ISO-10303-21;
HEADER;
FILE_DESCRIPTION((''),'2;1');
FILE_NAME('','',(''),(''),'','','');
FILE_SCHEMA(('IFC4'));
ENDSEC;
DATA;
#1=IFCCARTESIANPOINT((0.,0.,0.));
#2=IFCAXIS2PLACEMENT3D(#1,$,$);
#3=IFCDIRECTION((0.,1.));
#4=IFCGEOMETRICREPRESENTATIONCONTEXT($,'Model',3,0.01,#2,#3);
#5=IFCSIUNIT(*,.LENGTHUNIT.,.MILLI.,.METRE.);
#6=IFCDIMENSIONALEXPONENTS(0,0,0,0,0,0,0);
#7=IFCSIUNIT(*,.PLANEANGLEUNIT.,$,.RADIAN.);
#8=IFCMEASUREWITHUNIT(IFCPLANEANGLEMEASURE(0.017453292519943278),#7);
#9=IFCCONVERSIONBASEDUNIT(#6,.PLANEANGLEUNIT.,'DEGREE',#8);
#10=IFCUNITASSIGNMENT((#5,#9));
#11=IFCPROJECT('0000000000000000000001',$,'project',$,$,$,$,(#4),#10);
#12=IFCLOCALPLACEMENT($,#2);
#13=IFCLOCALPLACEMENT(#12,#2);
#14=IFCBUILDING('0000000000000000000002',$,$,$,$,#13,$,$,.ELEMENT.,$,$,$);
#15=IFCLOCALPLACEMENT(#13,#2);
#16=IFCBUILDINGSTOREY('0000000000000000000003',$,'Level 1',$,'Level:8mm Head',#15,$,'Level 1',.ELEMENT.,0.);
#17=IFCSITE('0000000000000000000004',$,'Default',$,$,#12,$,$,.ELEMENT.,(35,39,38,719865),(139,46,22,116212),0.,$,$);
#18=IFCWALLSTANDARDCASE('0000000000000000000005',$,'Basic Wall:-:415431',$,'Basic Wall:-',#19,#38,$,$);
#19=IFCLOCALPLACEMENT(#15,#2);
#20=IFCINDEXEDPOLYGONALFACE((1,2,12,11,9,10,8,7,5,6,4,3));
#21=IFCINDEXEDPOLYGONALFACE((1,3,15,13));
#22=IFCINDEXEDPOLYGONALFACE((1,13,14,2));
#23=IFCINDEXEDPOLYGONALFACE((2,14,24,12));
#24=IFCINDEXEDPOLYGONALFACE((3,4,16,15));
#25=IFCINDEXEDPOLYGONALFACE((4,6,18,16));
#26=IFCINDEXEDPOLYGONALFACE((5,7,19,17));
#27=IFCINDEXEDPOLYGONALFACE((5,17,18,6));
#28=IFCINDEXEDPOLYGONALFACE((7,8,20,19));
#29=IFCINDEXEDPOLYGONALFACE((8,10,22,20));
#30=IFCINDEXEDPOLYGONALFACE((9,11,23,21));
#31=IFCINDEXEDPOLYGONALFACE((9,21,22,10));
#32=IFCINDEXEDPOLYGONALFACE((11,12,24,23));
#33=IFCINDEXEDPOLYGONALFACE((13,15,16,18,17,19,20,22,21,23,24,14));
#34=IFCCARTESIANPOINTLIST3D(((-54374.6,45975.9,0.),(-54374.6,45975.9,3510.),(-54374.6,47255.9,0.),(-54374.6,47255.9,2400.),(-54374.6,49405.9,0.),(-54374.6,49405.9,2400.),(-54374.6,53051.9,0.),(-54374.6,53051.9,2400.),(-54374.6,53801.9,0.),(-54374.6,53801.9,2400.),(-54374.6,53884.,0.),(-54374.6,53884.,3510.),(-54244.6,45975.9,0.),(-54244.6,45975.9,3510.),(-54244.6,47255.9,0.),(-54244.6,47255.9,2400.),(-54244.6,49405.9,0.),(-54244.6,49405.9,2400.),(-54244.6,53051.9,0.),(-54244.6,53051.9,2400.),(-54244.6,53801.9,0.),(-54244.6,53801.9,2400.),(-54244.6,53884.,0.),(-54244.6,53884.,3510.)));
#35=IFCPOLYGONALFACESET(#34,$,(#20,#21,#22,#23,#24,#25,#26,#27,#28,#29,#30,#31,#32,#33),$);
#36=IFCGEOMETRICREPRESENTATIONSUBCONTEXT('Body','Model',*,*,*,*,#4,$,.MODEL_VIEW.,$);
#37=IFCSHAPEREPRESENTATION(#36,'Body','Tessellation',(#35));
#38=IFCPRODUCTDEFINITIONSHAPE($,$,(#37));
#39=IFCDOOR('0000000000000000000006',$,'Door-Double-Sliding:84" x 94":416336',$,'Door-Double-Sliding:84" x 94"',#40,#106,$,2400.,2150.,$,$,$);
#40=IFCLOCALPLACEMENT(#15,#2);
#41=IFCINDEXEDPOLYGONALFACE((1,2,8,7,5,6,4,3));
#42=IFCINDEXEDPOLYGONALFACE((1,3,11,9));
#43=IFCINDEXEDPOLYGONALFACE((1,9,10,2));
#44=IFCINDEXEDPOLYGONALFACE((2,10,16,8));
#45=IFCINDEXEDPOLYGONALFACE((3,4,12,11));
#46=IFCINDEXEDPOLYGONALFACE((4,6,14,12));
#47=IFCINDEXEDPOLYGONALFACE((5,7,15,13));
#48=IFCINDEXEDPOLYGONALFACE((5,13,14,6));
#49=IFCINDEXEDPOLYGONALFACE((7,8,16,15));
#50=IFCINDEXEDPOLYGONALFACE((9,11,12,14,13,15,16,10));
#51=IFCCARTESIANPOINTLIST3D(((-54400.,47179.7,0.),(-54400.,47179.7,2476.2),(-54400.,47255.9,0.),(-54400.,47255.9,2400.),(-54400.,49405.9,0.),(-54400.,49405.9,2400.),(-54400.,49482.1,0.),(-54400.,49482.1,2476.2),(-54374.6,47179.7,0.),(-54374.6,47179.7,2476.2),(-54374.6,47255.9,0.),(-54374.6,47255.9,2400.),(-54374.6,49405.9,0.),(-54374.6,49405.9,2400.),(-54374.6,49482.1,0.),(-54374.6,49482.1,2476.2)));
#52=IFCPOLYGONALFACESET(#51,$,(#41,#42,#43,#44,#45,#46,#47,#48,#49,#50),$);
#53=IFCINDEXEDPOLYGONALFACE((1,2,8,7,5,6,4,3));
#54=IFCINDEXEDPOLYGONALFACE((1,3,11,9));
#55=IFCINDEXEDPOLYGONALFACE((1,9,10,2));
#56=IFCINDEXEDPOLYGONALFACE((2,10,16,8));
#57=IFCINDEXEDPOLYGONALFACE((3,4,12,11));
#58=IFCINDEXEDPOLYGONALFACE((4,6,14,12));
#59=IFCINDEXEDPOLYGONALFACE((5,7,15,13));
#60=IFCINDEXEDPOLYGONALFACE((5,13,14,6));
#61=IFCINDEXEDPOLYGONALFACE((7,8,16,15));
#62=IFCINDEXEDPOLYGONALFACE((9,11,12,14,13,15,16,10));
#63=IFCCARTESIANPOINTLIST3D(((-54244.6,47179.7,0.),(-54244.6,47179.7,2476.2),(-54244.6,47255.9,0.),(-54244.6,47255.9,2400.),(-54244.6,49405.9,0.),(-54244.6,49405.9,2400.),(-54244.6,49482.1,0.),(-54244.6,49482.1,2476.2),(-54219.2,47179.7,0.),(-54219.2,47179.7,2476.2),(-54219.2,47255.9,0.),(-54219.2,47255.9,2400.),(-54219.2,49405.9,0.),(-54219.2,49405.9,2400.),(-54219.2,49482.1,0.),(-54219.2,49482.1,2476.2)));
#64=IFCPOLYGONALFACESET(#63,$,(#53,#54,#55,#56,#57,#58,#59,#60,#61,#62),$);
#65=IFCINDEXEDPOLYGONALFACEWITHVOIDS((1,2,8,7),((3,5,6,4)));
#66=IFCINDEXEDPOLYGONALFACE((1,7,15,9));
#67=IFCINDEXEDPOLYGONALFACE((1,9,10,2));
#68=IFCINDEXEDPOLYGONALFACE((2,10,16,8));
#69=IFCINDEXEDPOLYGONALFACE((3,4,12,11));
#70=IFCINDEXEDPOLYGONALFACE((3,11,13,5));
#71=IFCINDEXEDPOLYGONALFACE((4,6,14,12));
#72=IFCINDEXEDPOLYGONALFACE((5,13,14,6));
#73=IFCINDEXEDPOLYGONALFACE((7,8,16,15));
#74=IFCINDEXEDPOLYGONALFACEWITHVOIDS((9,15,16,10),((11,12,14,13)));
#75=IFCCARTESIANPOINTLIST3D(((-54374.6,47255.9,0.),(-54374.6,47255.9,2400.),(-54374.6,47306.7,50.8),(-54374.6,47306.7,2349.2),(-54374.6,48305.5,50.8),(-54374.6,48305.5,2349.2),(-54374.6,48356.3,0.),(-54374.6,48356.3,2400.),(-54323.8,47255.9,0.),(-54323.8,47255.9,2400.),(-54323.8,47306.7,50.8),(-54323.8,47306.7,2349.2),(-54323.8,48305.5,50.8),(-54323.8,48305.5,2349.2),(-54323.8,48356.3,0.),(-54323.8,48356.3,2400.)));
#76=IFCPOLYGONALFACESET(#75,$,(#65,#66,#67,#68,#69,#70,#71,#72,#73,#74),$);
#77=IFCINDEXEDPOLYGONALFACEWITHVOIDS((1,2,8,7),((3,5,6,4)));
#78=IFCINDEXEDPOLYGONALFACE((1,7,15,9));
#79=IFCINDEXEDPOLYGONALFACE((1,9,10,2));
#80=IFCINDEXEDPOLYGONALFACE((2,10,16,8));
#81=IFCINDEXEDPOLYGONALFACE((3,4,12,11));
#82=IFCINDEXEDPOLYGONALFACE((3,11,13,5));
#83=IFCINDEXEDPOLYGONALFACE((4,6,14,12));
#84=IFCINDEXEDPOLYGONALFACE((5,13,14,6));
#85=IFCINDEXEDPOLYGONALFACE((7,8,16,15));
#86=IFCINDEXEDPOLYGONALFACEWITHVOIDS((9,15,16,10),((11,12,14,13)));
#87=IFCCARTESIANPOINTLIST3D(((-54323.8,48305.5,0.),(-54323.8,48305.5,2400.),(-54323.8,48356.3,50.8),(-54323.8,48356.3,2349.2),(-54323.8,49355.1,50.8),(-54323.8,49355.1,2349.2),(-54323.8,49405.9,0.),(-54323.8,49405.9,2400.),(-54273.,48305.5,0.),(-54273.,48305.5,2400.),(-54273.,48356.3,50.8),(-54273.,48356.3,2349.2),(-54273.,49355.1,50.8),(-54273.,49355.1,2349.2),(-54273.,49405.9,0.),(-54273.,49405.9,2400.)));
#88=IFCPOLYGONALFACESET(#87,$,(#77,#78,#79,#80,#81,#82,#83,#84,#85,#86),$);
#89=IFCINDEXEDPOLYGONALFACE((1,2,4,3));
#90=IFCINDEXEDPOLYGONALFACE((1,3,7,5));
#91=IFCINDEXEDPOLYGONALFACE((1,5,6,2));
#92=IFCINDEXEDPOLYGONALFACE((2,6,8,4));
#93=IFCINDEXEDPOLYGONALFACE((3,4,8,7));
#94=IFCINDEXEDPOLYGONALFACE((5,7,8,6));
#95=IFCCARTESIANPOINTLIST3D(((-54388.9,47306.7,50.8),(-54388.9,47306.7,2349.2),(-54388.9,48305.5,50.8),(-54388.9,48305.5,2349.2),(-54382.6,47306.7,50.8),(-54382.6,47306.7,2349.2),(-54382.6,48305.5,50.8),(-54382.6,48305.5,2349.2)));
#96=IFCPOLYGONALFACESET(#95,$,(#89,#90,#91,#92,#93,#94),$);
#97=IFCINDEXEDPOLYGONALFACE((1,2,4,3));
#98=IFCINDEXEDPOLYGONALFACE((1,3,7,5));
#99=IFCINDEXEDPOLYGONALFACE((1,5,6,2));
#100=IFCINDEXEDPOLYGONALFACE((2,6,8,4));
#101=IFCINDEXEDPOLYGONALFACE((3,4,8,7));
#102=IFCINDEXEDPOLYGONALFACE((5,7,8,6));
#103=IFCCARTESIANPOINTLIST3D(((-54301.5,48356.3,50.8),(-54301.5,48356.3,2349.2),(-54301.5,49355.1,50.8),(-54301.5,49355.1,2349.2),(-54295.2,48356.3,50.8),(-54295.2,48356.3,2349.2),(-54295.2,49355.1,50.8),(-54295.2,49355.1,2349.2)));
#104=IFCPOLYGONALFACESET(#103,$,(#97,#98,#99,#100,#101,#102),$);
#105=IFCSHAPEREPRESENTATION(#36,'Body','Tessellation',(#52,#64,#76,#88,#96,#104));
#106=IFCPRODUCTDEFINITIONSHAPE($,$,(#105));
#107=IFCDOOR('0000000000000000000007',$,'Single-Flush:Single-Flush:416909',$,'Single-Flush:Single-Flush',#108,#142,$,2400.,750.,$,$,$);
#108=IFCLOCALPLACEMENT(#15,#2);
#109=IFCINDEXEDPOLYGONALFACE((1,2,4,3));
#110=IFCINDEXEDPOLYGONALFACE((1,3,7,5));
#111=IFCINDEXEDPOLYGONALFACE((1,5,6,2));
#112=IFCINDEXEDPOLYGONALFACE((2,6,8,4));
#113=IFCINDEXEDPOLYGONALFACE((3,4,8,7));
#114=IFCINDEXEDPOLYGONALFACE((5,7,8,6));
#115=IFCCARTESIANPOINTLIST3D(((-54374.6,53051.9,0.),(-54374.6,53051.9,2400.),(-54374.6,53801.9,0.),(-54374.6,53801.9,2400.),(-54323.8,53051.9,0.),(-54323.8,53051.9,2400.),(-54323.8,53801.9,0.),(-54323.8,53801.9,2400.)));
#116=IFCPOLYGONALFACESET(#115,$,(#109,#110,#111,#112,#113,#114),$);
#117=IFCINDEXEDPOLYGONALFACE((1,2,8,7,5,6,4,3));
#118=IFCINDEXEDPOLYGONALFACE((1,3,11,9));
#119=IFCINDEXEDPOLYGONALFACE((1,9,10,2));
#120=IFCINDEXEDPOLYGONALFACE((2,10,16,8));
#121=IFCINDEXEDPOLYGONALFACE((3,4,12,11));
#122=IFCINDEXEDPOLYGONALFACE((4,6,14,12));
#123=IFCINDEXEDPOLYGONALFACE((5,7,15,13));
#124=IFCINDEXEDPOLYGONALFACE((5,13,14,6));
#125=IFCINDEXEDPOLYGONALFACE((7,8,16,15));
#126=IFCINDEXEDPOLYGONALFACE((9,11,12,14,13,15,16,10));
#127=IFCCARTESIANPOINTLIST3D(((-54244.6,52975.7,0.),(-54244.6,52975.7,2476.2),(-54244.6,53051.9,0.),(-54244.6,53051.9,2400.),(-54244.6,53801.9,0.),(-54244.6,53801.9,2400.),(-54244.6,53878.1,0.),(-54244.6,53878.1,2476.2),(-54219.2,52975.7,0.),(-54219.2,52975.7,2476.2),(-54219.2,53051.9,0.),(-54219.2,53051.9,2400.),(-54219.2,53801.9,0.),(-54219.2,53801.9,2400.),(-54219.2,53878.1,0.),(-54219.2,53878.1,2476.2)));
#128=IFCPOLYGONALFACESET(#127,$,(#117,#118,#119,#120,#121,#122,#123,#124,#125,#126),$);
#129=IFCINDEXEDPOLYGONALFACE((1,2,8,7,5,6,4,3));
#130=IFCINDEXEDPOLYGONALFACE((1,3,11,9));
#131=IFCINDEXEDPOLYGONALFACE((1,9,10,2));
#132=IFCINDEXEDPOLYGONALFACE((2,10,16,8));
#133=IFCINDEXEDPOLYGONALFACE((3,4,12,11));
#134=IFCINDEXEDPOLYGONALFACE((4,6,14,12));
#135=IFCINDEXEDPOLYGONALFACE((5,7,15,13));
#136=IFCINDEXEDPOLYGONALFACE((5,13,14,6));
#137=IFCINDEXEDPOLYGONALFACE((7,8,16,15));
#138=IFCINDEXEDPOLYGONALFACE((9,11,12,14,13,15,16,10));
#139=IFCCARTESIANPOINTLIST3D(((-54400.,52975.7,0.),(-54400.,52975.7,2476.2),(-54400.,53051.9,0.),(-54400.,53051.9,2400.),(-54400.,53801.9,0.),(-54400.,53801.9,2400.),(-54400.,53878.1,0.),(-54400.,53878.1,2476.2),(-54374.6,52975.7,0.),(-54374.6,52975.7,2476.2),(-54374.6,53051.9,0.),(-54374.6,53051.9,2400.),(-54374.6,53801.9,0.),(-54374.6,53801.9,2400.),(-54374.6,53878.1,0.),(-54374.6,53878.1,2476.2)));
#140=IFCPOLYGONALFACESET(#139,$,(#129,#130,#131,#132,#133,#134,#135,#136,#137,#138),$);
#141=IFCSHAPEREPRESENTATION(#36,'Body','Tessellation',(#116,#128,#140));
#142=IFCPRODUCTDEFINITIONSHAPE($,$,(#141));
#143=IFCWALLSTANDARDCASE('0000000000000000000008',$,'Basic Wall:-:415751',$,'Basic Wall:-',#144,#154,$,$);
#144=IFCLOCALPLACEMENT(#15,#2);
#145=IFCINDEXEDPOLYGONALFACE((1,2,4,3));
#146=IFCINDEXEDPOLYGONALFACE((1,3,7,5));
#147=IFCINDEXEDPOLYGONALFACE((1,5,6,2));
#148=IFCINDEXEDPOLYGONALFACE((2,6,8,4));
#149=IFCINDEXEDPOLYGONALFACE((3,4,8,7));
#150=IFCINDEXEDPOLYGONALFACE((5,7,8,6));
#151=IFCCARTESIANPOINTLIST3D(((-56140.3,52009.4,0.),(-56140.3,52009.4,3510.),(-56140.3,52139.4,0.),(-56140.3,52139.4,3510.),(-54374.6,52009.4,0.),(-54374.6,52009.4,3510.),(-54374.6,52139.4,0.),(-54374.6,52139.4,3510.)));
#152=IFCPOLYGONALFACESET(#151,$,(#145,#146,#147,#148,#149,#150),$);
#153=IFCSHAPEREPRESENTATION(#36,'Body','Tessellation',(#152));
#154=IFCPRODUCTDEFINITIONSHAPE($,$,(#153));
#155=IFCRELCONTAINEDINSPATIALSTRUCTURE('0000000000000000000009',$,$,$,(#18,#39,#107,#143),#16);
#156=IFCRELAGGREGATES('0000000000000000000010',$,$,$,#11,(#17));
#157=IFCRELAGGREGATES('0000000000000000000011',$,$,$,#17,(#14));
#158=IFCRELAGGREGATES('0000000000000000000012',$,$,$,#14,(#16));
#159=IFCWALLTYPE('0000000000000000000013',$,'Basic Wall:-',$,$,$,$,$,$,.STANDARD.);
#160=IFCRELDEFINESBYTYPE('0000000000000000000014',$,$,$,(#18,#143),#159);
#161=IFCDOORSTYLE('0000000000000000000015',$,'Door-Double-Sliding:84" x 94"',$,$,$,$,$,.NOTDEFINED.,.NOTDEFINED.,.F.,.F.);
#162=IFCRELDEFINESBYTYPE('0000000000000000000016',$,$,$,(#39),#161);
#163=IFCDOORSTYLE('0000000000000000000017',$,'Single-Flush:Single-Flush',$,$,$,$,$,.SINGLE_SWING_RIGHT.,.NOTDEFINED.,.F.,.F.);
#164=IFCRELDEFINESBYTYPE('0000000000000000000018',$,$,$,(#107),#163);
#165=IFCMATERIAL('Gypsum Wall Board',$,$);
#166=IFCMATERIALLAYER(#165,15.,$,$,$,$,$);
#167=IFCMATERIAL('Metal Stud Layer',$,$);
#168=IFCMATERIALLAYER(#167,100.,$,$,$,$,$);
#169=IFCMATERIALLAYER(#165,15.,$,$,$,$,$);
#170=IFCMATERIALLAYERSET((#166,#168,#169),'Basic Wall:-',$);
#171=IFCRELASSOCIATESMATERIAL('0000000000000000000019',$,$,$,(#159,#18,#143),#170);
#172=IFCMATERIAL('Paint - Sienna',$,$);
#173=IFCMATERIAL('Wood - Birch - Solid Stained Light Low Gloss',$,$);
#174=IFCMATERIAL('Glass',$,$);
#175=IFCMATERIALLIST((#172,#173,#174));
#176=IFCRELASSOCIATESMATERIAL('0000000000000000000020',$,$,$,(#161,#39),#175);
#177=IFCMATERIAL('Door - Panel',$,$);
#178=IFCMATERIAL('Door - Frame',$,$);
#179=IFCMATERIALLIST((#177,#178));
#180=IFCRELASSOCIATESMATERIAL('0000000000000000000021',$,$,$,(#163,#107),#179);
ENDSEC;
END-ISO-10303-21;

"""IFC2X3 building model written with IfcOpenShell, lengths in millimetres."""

from ifc_helpers import new_model, entity, si_unit, converted_unit, direction, frame, frame_2d, origin, origin_2d_with_axis, place, context, subcontext, project, spatial, polyline, rectangle, outline, extrude, source, transform, mapped, material, material_list, layer, layer_set, layer_usage, type_object, type_shapes, element, fill, save


model = new_model("IFC2X3")

# Units and contexts
model_context = context("Model", 3, precision=0.01, world=origin(), true_north=direction((0.0, 1.0)))
body_context = subcontext(model_context, "Body", "Model", "MODEL_VIEW")
ifc_project = project(units=[si_unit("LENGTHUNIT", "METRE", prefix="MILLI"), converted_unit("PLANEANGLEUNIT", "DEGREE", entity("IfcPlaneAngleMeasure", 0.017453292519943278), si_unit("PLANEANGLEUNIT", "RADIAN"), dimensions=[0, 0, 0, 0, 0, 0, 0])], contexts=[model_context])

# Site, building, storey
site_placement = place(None, origin())
site = spatial("IfcSite", under=ifc_project, at=site_placement, Name="Default", CompositionType="ELEMENT", RefLatitude=(35, 39, 38, 719865), RefLongitude=(139, 46, 22, 116212), RefElevation=0.0)
building_placement = place(site_placement, origin())
building = spatial("IfcBuilding", under=site, at=building_placement, CompositionType="ELEMENT")
storey_placement = place(building_placement, origin())
storey = spatial("IfcBuildingStorey", under=building, at=storey_placement, Name="Level 1", ObjectType="Level:8mm Head", LongName="Level 1", CompositionType="ELEMENT", Elevation=0.0)

# Shared definitions
ifc_material_1 = material(Name="Glass")

# Wall, openings, doors
ifc_material_2 = material(Name="Gypsum Wall Board")
ifc_layer_1 = layer(ifc_material_2, 15.0)
ifc_material_3 = material(Name="Metal Stud Layer")
ifc_layer_2 = layer(ifc_material_3, 100.0)
ifc_layer_3 = layer(ifc_material_2, 15.0)
ifc_layer_set = layer_set([ifc_layer_1, ifc_layer_2, ifc_layer_3], Name="Basic Wall:-")
ifc_layer_usage_1 = layer_usage(ifc_layer_set, "AXIS2", "NEGATIVE", 65.0)
wall_type = type_object("IfcWallType", Name="Basic Wall:-", PredefinedType="STANDARD", material=ifc_layer_set)
wall_1_placement = place(storey_placement, frame((-54309.6, 45975.9, 0.0), z_axis=(0.0, 0.0, 1.0), x_axis=(0.0, 1.0, 0.0)))
wall_1 = element("IfcWallStandardCase", 1, at=wall_1_placement, inside=storey, type_object=wall_type, material=ifc_layer_usage_1, Name="Basic Wall:-:415431", ObjectType="Basic Wall:-", context=body_context, shape_type="SweptSolid", body=[
    extrude(rectangle(XDim=7908.1, YDim=130.0, at=frame_2d((3954.1, 0.0), x_axis=(-1.0, 0.0))), origin(), (0.0, 0.0, 1.0), 3510.0),
])
opening_1_placement = place(wall_1_placement, frame((1280.0, -65.0, 0.0)))
opening_1 = element("IfcOpeningElement", 2, at=opening_1_placement, cuts=wall_1, ObjectType="Opening", context=body_context, shape_type="SweptSolid", body=[
    extrude(rectangle(XDim=2400.0, YDim=2150.0, at=frame_2d((1200.0, 1075.0), x_axis=(-1.0, 0.0))), frame((0.0, 0.0, 0.0), z_axis=(0.0, 1.0, 0.0), x_axis=(0.0, 0.0, 1.0)), (0.0, 0.0, 1.0), 130.0),
])
opening_2_placement = place(wall_1_placement, frame((7075.9, -65.0, 0.0)))
opening_2 = element("IfcOpeningElement", 3, at=opening_2_placement, cuts=wall_1, ObjectType="Opening", context=body_context, shape_type="SweptSolid", body=[
    extrude(rectangle(XDim=750.0, YDim=2400.0, at=frame_2d((1200.0, 375.0), x_axis=(0.0, 1.0))), frame((0.0, 0.0, 0.0), z_axis=(0.0, 1.0, 0.0), x_axis=(0.0, 0.0, 1.0)), (0.0, 0.0, 1.0), 130.0),
])
ifc_material_4 = material(Name="Paint - Sienna")
ifc_material_5 = material(Name="Wood - Birch - Solid Stained Light Low Gloss")
ifc_material_list_1 = material_list([ifc_material_4, ifc_material_5, ifc_material_1])
door_style_1 = type_object("IfcDoorStyle", Name="Door-Double-Sliding:84\" x 94\"", ConstructionType="NOTDEFINED", OperationType="NOTDEFINED", ParameterTakesPrecedence=False, Sizeable=False, material=ifc_material_list_1)
shared_shape_1 = source(origin(), body_context, "Body", "SweptSolid", [
    extrude(outline(polyline([(-1151.2, -1219.0), (-1075.0, -1219.0), (-1075.0, 1181.0), (1075.0, 1180.9), (1075.0, -1219.1), (1151.2, -1219.1), (1151.2, 1257.1), (-1151.2, 1257.2), (-1151.2, -1219.0)])), frame((1075.0, 130.0, 1219.0), z_axis=(0.0, 1.0, 0.0), x_axis=(-1.0, 0.0, 0.0)), (0.0, 0.0, 1.0), 25.4),
    extrude(outline(polyline([(-1219.0, -1151.2), (1257.1, -1151.2), (1257.1, 1151.2), (-1219.0, 1151.2), (-1219.0, 1075.0), (1180.9, 1075.0), (1180.9, -1075.0), (-1219.0, -1075.0), (-1219.0, -1151.2)])), frame((1075.0, -25.4, 1219.0), z_axis=(0.0, 1.0, 0.0), x_axis=(0.0, 0.0, 1.0)), (0.0, 0.0, 1.0), 25.4),
    extrude(outline(polyline([(-1200.0, -550.2), (1200.0, -550.2), (1200.0, 550.2), (-1200.0, 550.2), (-1200.0, -550.2)]), holes=[polyline([(-1149.2, -499.4), (-1149.2, 499.4), (1149.2, 499.4), (1149.2, -499.4), (-1149.2, -499.4)])]), frame((550.2, 79.2, 1200.0), z_axis=(0.0, 1.0, 0.0), x_axis=(0.0, 0.0, -1.0)), (0.0, 0.0, 1.0), 50.8),
    extrude(outline(polyline([(-550.2, -1200.0), (550.2, -1200.0), (550.2, 1200.0), (-550.2, 1200.0), (-550.2, -1200.0)]), holes=[polyline([(-499.4, -1149.2), (-499.4, 1149.2), (499.4, 1149.2), (499.4, -1149.2), (-499.4, -1149.2)])]), frame((1599.8, 28.4, 1200.0), z_axis=(0.0, 1.0, 0.0), x_axis=(1.0, 0.0, 0.0)), (0.0, 0.0, 1.0), 50.8),
    extrude(rectangle(XDim=6.4, YDim=998.8, at=origin_2d_with_axis()), frame((550.2, 141.2, 50.8), z_axis=(0.0, 0.0, 1.0), x_axis=(0.0, 1.0, 0.0)), (0.0, 0.0, 1.0), 2298.4),
    extrude(rectangle(XDim=6.3, YDim=998.8, at=frame_2d((0.0, 0.0), x_axis=(1.0, 0.0))), frame((1599.8, 53.8, 50.8), z_axis=(0.0, 0.0, 1.0), x_axis=(0.0, -1.0, 0.0)), (0.0, 0.0, 1.0), 2298.4),
])
type_shapes(door_style_1, [shared_shape_1])
door_1_placement = place(opening_1_placement, origin())
door_1 = element("IfcDoor", 4, at=door_1_placement, inside=storey, type_object=door_style_1, material=ifc_material_list_1, Name="Door-Double-Sliding:84\" x 94\":416336", ObjectType="Door-Double-Sliding:84\" x 94\"", OverallHeight=2400.0, OverallWidth=2150.0, context=body_context, shape_type="MappedRepresentation", body=[
    mapped(shared_shape_1, transform((0.0, 0.0, 0.0), scale=1.0)),
])
fill(opening_1, door_1)
ifc_material_6 = material(Name="Door - Panel")
ifc_material_7 = material(Name="Door - Frame")
ifc_material_list_2 = material_list([ifc_material_6, ifc_material_7])
door_style_2 = type_object("IfcDoorStyle", Name="Single-Flush:Single-Flush", ConstructionType="NOTDEFINED", OperationType="SINGLE_SWING_RIGHT", ParameterTakesPrecedence=False, Sizeable=False, material=ifc_material_list_2)
shared_shape_2 = source(origin(), body_context, "Body", "SweptSolid", [
    extrude(rectangle(XDim=50.8, YDim=750.0, at=frame_2d((0.0, 0.0), x_axis=(1.0, 0.0))), frame((375.0, 104.6, 0.0), z_axis=(0.0, 0.0, 1.0), x_axis=(0.0, 1.0, 0.0)), (0.0, 0.0, 1.0), 2400.0),
    extrude(outline(polyline([(-1257.1, -451.2), (1219.0, -451.2), (1219.0, -375.0), (-1180.9, -375.0), (-1180.9, 375.0), (1219.0, 375.0), (1219.0, 451.2), (-1257.1, 451.2), (-1257.1, -451.2)])), frame((375.0, -25.4, 1219.0), z_axis=(0.0, 1.0, 0.0), x_axis=(0.0, 0.0, -1.0)), (0.0, 0.0, 1.0), 25.4),
    extrude(outline(polyline([(-451.2, -1257.1), (451.2, -1257.1), (451.2, 1219.1), (375.0, 1219.1), (375.0, -1181.0), (-375.0, -1181.0), (-375.0, 1219.1), (-451.2, 1219.1), (-451.2, -1257.1)])), frame((375.0, 130.0, 1219.1), z_axis=(0.0, 1.0, 0.0), x_axis=(1.0, 0.0, 0.0)), (0.0, 0.0, 1.0), 25.4),
])
type_shapes(door_style_2, [shared_shape_2])
door_2_placement = place(opening_2_placement, origin())
door_2 = element("IfcDoor", 5, at=door_2_placement, inside=storey, type_object=door_style_2, material=ifc_material_list_2, Name="Single-Flush:Single-Flush:416909", ObjectType="Single-Flush:Single-Flush", OverallHeight=2400.0, OverallWidth=750.0, context=body_context, shape_type="MappedRepresentation", body=[
    mapped(shared_shape_2, transform((0.0, 0.0, 0.0), scale=1.0)),
])
fill(opening_2, door_2)

# Wall
ifc_layer_usage_2 = layer_usage(ifc_layer_set, "AXIS2", "NEGATIVE", 65.0)
wall_2_placement = place(storey_placement, frame((-54374.6, 52074.4, 0.0), z_axis=(0.0, 0.0, 1.0), x_axis=(-1.0, 0.0, 0.0)))
element("IfcWallStandardCase", 6, at=wall_2_placement, inside=storey, type_object=wall_type, material=ifc_layer_usage_2, Name="Basic Wall:-:415751", ObjectType="Basic Wall:-", context=body_context, shape_type="SweptSolid", body=[
    extrude(rectangle(XDim=1765.7, YDim=130.0, at=frame_2d((882.9, 0.0), x_axis=(-1.0, 0.0))), origin(), (0.0, 0.0, 1.0), 3510.0),
])

save(model, "model.ifc")
